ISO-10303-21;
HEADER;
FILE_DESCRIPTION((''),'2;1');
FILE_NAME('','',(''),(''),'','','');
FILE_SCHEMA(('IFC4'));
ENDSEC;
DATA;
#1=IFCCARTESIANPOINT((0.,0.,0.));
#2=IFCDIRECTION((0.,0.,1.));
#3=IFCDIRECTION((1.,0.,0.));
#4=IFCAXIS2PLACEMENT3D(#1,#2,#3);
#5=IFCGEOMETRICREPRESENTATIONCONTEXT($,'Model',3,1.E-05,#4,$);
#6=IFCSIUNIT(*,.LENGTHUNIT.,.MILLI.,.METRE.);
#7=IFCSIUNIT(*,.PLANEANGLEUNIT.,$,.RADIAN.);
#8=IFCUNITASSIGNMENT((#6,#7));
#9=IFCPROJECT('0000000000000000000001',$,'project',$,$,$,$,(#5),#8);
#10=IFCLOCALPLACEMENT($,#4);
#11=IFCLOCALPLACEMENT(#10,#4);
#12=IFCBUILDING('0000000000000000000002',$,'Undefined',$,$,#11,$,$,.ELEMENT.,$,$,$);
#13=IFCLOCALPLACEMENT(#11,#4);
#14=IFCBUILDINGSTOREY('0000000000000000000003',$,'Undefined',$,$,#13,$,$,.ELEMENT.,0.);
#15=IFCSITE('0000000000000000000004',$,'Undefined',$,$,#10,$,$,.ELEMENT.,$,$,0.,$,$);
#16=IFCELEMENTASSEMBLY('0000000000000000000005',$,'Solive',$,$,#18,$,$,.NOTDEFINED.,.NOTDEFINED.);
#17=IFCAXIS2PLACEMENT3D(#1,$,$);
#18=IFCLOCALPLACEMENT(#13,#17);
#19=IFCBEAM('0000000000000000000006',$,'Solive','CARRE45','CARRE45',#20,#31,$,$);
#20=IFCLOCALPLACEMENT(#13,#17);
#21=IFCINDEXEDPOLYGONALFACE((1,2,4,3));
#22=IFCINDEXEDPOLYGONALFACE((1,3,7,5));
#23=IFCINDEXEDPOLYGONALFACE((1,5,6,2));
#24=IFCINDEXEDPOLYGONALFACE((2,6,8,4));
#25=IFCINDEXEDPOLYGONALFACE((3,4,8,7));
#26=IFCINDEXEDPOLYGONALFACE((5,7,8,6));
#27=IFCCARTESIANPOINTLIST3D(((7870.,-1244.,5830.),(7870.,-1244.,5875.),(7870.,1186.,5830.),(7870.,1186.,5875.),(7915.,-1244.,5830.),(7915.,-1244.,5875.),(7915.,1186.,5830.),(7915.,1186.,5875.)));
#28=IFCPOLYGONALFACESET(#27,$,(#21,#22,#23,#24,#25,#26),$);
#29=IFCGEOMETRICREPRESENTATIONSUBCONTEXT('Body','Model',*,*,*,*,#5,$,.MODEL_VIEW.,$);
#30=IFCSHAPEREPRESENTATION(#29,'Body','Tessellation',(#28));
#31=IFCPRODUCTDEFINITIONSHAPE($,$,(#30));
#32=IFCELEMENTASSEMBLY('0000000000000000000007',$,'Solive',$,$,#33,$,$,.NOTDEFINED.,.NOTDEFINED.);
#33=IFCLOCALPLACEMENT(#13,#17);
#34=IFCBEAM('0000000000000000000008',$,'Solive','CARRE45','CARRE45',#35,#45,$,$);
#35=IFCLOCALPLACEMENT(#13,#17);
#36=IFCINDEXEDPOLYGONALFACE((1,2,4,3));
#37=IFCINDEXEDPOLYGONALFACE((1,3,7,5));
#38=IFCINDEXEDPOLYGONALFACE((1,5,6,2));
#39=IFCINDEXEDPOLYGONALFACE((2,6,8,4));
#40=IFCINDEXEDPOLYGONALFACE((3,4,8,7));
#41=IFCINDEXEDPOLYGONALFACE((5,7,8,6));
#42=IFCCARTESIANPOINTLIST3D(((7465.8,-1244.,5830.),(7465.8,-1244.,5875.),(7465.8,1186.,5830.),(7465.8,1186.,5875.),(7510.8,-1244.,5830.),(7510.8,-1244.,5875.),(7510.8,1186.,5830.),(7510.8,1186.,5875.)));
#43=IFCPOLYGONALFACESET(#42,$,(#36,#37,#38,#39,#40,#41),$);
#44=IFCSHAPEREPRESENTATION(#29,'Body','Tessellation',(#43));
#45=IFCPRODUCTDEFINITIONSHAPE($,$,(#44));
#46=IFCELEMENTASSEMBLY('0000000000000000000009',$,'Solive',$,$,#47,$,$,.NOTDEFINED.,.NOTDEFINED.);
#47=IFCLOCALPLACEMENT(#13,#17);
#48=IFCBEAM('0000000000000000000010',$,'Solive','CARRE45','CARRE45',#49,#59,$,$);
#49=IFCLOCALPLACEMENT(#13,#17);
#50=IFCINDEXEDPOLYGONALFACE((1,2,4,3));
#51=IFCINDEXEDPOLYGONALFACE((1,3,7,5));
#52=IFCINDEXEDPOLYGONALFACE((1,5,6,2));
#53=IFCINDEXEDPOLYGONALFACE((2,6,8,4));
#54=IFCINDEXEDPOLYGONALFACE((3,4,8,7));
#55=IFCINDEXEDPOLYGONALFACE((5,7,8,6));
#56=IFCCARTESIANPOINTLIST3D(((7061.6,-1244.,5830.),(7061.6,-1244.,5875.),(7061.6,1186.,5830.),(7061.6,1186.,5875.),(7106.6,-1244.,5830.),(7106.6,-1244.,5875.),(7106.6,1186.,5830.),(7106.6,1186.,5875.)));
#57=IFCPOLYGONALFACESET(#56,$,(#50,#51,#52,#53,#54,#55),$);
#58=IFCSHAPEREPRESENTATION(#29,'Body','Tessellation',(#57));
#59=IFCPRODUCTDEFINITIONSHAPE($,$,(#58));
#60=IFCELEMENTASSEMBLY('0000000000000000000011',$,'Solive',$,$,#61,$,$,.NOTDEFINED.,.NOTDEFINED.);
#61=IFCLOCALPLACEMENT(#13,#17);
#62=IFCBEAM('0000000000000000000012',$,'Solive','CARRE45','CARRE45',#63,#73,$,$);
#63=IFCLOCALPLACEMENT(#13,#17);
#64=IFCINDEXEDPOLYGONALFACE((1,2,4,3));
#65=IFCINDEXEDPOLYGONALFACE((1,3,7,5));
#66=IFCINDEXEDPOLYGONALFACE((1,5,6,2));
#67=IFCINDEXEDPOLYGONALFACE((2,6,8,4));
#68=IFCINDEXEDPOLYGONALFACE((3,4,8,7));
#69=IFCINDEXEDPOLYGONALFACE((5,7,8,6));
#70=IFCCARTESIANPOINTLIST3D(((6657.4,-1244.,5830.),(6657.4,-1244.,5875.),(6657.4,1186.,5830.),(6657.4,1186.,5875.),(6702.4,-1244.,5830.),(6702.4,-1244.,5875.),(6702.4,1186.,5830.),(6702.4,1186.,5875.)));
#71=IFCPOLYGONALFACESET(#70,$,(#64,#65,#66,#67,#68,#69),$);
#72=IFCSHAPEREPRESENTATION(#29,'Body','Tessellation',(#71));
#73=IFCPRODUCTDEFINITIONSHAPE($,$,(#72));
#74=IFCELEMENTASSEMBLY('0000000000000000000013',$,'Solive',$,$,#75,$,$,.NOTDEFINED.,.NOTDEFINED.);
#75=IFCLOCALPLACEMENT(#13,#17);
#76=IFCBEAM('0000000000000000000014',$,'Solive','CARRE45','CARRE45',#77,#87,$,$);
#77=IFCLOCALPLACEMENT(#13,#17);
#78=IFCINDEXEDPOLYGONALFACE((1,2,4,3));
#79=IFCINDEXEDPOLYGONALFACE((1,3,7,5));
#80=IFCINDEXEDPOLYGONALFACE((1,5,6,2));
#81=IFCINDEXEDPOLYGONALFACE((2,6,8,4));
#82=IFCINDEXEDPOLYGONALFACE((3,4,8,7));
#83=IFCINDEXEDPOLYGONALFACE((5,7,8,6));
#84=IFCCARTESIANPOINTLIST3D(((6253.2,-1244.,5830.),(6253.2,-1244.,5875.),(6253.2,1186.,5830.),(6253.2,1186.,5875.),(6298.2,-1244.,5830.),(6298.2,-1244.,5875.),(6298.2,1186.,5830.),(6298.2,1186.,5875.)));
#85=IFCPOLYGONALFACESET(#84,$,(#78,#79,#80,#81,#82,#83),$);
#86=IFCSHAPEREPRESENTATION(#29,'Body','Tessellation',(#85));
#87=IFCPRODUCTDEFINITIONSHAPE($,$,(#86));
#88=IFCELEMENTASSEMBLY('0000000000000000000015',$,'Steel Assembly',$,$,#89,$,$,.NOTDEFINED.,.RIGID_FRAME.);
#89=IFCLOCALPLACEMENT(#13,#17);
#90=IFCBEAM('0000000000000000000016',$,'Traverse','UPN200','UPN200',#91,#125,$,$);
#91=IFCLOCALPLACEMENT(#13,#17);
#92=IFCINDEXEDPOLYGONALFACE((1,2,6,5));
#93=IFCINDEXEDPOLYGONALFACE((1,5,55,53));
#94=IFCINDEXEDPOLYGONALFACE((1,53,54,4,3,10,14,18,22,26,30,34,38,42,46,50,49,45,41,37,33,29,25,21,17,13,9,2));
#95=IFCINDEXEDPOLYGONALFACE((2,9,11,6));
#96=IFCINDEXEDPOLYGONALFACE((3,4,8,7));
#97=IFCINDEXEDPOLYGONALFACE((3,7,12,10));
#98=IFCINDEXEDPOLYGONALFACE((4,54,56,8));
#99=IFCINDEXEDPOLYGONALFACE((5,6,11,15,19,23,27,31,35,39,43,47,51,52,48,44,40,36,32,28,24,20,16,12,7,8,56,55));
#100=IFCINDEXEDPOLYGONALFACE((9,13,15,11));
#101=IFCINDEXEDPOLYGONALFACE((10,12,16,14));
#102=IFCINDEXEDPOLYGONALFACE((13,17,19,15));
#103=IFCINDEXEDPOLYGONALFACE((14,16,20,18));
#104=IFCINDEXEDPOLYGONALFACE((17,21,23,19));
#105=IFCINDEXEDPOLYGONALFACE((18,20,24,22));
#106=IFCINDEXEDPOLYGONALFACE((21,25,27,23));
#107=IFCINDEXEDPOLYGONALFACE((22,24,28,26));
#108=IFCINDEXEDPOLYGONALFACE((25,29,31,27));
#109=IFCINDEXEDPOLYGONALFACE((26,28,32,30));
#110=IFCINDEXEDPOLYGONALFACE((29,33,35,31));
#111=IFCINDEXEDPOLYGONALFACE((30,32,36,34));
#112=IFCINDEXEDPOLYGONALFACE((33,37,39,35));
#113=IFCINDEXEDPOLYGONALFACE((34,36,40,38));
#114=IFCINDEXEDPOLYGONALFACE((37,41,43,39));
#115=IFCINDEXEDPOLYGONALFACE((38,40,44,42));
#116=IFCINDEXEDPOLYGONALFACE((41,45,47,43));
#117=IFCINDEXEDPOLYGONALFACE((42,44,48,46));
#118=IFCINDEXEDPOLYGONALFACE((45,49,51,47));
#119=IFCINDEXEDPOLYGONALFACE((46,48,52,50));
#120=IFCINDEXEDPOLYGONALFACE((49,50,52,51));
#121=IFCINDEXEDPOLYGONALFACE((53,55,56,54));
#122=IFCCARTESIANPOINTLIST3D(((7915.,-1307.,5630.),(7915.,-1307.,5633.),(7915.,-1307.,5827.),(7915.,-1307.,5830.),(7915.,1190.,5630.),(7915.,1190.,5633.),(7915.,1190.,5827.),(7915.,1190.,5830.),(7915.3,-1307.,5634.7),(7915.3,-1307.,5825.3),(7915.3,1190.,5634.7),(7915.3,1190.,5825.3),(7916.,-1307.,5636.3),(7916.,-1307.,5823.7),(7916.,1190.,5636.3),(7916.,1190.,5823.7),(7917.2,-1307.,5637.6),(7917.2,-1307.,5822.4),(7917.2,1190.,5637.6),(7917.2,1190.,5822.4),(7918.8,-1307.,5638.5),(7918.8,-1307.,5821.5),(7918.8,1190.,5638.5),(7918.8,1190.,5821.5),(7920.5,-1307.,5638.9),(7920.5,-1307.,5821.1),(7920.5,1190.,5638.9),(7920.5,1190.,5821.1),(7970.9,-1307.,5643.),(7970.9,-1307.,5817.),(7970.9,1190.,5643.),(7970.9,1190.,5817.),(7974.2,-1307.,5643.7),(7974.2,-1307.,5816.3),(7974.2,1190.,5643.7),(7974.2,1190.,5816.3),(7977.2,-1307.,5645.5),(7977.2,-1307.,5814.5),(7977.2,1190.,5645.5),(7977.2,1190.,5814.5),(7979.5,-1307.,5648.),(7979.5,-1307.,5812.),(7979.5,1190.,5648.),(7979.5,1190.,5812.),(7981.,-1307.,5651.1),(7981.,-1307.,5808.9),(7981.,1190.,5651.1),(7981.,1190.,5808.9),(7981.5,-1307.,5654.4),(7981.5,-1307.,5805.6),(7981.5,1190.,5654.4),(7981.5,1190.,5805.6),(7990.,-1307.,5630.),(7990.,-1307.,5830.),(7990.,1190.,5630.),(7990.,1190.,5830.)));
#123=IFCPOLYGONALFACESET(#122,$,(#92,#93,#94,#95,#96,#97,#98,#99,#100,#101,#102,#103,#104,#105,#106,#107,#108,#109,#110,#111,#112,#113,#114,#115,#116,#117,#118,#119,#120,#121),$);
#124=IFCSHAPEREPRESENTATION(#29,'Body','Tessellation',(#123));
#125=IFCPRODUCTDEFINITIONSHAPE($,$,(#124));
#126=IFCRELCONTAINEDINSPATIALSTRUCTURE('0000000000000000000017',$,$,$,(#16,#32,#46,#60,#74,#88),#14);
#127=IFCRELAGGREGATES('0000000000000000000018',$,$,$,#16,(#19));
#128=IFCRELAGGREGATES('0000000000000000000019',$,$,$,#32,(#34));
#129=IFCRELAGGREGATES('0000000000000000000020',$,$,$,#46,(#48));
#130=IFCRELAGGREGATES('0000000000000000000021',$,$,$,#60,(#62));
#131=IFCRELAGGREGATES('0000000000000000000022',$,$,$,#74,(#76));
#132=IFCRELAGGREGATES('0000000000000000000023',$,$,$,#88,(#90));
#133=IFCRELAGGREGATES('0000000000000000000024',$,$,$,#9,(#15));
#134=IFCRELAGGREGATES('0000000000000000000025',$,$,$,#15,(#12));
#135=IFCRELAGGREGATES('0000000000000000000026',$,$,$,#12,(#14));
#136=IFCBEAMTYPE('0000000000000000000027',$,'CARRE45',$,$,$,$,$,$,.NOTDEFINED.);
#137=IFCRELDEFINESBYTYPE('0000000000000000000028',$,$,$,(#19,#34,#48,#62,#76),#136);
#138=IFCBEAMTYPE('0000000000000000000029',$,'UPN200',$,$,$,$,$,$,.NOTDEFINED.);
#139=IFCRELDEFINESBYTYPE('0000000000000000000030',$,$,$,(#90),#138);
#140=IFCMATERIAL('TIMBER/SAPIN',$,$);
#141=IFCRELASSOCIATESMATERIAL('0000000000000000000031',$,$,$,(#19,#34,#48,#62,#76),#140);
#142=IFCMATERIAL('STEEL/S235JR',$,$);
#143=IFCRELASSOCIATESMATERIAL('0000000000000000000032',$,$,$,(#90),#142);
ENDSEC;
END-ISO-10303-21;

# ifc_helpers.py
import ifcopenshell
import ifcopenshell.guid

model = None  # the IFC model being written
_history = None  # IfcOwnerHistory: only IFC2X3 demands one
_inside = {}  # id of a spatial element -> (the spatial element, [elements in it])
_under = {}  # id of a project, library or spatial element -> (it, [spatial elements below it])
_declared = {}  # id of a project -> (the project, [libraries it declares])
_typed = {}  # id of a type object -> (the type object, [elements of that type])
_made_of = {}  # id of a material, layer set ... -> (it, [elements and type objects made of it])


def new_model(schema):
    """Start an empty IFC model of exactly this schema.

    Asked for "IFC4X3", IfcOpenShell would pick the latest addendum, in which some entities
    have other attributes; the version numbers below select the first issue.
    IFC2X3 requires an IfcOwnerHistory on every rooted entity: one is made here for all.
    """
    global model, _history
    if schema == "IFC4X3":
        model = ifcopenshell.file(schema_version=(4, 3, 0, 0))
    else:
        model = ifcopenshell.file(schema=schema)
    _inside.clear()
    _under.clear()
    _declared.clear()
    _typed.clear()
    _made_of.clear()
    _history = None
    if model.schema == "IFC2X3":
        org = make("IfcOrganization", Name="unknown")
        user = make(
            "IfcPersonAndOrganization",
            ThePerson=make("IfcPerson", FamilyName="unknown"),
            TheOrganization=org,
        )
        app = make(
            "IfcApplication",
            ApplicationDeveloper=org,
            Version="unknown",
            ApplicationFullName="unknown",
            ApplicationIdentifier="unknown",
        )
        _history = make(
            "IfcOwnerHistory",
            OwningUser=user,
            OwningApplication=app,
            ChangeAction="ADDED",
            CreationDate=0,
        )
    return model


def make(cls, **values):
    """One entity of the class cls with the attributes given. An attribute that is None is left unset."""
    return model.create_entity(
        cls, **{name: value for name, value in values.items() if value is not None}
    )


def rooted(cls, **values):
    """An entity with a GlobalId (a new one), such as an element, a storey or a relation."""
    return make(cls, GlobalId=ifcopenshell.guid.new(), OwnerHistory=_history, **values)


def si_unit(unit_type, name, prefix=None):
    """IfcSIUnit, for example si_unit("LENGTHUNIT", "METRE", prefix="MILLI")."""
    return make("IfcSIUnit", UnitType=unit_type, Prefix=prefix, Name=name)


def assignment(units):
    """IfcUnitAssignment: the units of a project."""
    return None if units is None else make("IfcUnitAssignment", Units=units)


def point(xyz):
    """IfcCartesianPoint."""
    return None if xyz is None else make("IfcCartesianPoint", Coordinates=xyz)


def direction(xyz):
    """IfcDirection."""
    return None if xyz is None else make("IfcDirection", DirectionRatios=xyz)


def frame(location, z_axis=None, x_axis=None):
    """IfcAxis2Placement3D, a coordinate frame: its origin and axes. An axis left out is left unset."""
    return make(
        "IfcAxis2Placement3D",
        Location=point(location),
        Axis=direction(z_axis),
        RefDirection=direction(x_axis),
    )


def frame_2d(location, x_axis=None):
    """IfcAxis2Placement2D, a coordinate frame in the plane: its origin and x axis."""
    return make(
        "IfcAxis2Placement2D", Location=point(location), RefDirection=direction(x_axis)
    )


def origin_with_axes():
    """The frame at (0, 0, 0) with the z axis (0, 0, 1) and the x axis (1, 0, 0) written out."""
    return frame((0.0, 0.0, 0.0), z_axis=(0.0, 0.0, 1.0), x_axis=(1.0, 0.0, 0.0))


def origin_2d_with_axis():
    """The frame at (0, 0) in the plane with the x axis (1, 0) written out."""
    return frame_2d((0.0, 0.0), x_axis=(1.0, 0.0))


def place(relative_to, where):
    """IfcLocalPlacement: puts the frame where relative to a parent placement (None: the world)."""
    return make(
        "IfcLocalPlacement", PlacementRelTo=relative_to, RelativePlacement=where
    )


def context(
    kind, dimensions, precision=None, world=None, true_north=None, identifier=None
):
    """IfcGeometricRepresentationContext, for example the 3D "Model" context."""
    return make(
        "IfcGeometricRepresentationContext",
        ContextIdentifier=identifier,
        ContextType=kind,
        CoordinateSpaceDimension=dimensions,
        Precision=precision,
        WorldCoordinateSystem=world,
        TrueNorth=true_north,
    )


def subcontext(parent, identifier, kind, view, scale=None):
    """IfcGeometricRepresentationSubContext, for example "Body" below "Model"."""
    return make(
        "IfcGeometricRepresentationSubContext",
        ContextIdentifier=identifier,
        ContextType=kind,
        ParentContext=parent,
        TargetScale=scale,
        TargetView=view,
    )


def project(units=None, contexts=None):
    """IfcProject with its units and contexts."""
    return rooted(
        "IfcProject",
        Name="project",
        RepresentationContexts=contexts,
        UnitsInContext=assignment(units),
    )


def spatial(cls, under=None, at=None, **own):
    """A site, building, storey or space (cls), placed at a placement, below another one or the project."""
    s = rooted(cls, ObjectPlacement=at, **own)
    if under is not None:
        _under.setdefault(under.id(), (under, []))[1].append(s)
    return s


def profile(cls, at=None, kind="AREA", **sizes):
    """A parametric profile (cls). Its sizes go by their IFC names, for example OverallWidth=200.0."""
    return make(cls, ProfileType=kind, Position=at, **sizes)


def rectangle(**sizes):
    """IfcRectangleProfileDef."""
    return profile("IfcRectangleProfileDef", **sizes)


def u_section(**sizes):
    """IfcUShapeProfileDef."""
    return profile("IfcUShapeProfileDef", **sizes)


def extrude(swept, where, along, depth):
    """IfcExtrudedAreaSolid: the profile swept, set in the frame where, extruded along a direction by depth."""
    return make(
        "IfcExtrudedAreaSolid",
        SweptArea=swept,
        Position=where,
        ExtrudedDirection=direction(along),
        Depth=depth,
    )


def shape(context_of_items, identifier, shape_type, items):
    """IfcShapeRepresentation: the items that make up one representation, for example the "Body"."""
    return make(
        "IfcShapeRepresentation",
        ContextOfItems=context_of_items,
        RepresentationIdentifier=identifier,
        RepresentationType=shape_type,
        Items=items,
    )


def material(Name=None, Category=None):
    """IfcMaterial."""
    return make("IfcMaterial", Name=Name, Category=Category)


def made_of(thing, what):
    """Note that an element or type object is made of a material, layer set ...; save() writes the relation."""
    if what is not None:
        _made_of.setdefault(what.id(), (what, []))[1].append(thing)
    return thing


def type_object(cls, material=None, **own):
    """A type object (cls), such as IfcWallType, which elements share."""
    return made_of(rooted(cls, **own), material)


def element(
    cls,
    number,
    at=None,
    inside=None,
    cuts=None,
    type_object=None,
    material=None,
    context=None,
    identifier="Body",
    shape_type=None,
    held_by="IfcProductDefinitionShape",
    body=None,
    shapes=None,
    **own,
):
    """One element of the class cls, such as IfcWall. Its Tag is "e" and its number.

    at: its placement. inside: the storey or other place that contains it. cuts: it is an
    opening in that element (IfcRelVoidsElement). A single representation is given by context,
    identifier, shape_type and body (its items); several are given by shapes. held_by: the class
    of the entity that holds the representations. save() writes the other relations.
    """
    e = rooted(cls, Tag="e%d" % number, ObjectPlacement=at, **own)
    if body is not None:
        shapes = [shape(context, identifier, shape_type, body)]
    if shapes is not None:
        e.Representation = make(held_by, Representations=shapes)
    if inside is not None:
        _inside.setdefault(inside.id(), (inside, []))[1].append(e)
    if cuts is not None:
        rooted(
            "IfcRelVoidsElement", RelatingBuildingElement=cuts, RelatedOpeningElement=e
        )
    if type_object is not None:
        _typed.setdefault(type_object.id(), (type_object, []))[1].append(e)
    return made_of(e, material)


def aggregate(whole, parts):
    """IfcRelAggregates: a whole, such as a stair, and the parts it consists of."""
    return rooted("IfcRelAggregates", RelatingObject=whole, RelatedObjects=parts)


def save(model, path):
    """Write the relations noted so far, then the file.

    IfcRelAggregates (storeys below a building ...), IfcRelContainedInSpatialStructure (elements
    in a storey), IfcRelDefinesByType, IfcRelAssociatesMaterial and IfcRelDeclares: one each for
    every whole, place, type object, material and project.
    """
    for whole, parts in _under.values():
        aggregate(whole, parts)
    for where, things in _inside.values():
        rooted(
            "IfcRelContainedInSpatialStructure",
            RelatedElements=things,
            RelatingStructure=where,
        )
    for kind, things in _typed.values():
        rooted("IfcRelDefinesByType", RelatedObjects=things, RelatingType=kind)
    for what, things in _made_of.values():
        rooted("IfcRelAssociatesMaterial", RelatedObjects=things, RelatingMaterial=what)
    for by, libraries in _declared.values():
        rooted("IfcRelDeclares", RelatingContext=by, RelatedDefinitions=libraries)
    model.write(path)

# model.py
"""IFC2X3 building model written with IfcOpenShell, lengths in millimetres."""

from ifc_helpers import new_model, si_unit, frame, origin_with_axes, origin_2d_with_axis, place, context, subcontext, project, spatial, rectangle, u_section, extrude, material, type_object, element, aggregate, save


model = new_model("IFC2X3")

# Units and contexts
model_context = context("Model", 3, precision=1e-05, world=origin_with_axes())
body_context = subcontext(model_context, "Body", "Model", "MODEL_VIEW")
ifc_project = project(units=[si_unit("LENGTHUNIT", "METRE", prefix="MILLI"), si_unit("PLANEANGLEUNIT", "RADIAN")], contexts=[model_context])

# Site, building, storey
site_placement = place(None, origin_with_axes())
site = spatial("IfcSite", under=ifc_project, at=site_placement, Name="Undefined", CompositionType="ELEMENT", RefElevation=0.0)
building_placement = place(site_placement, origin_with_axes())
building = spatial("IfcBuilding", under=site, at=building_placement, Name="Undefined", CompositionType="ELEMENT")
storey_placement = place(building_placement, origin_with_axes())
storey = spatial("IfcBuildingStorey", under=building, at=storey_placement, Name="Undefined", CompositionType="ELEMENT", Elevation=0.0)

# Element assemblies, beams
ifc_material_1 = material(Name="STEEL/S235JR")
assembly_1_placement = place(storey_placement, origin_with_axes())
assembly_1 = element("IfcElementAssembly", 1, at=assembly_1_placement, inside=storey, Name="Solive", AssemblyPlace="NOTDEFINED", PredefinedType="NOTDEFINED")
ifc_material_2 = material(Name="TIMBER/SAPIN")
beam_type_1 = type_object("IfcBeamType", Name="CARRE45", PredefinedType="NOTDEFINED")
beam_1_placement = place(assembly_1_placement, frame((7892.5, 1186.0, 5852.5), z_axis=(0.0, 0.0, -1.0), x_axis=(0.0, -1.0, 0.0)))
beam_1 = element("IfcBeam", 2, at=beam_1_placement, type_object=beam_type_1, material=ifc_material_2, Name="Solive", Description="CARRE45", ObjectType="CARRE45", context=body_context, shape_type="SweptSolid", body=[
    extrude(rectangle(XDim=45.0, YDim=45.0, at=origin_2d_with_axis()), frame((2430.0, 0.0, 0.0), z_axis=(-1.0, 0.0, 0.0), x_axis=(0.0, -1.0, 0.0)), (0.0, 0.0, 1.0), 2430.0),
])
aggregate(assembly_1, [beam_1])
assembly_2_placement = place(storey_placement, origin_with_axes())
assembly_2 = element("IfcElementAssembly", 3, at=assembly_2_placement, inside=storey, Name="Solive", AssemblyPlace="NOTDEFINED", PredefinedType="NOTDEFINED")
beam_2_placement = place(assembly_2_placement, frame((7488.3, 1186.0, 5852.5), z_axis=(0.0, 0.0, -1.0), x_axis=(0.0, -1.0, 0.0)))
beam_2 = element("IfcBeam", 4, at=beam_2_placement, type_object=beam_type_1, material=ifc_material_2, Name="Solive", Description="CARRE45", ObjectType="CARRE45", context=body_context, shape_type="SweptSolid", body=[
    extrude(rectangle(XDim=45.0, YDim=45.0, at=origin_2d_with_axis()), frame((2430.0, 0.0, 0.0), z_axis=(-1.0, 0.0, 0.0), x_axis=(0.0, -1.0, 0.0)), (0.0, 0.0, 1.0), 2430.0),
])
aggregate(assembly_2, [beam_2])
assembly_3_placement = place(storey_placement, origin_with_axes())
assembly_3 = element("IfcElementAssembly", 5, at=assembly_3_placement, inside=storey, Name="Solive", AssemblyPlace="NOTDEFINED", PredefinedType="NOTDEFINED")
beam_3_placement = place(assembly_3_placement, frame((7084.1, 1186.0, 5852.5), z_axis=(0.0, 0.0, -1.0), x_axis=(0.0, -1.0, 0.0)))
beam_3 = element("IfcBeam", 6, at=beam_3_placement, type_object=beam_type_1, material=ifc_material_2, Name="Solive", Description="CARRE45", ObjectType="CARRE45", context=body_context, shape_type="SweptSolid", body=[
    extrude(rectangle(XDim=45.0, YDim=45.0, at=origin_2d_with_axis()), frame((2430.0, 0.0, 0.0), z_axis=(-1.0, 0.0, 0.0), x_axis=(0.0, -1.0, 0.0)), (0.0, 0.0, 1.0), 2430.0),
])
aggregate(assembly_3, [beam_3])
assembly_4_placement = place(storey_placement, origin_with_axes())
assembly_4 = element("IfcElementAssembly", 7, at=assembly_4_placement, inside=storey, Name="Solive", AssemblyPlace="NOTDEFINED", PredefinedType="NOTDEFINED")
beam_4_placement = place(assembly_4_placement, frame((6679.9, 1186.0, 5852.5), z_axis=(0.0, 0.0, -1.0), x_axis=(0.0, -1.0, 0.0)))
beam_4 = element("IfcBeam", 8, at=beam_4_placement, type_object=beam_type_1, material=ifc_material_2, Name="Solive", Description="CARRE45", ObjectType="CARRE45", context=body_context, shape_type="SweptSolid", body=[
    extrude(rectangle(XDim=45.0, YDim=45.0, at=origin_2d_with_axis()), frame((2430.0, 0.0, 0.0), z_axis=(-1.0, 0.0, 0.0), x_axis=(0.0, -1.0, 0.0)), (0.0, 0.0, 1.0), 2430.0),
])
aggregate(assembly_4, [beam_4])
assembly_5_placement = place(storey_placement, origin_with_axes())
assembly_5 = element("IfcElementAssembly", 9, at=assembly_5_placement, inside=storey, Name="Solive", AssemblyPlace="NOTDEFINED", PredefinedType="NOTDEFINED")
beam_5_placement = place(assembly_5_placement, frame((6275.7, 1186.0, 5852.5), z_axis=(0.0, 0.0, -1.0), x_axis=(0.0, -1.0, 0.0)))
beam_5 = element("IfcBeam", 10, at=beam_5_placement, type_object=beam_type_1, material=ifc_material_2, Name="Solive", Description="CARRE45", ObjectType="CARRE45", context=body_context, shape_type="SweptSolid", body=[
    extrude(rectangle(XDim=45.0, YDim=45.0, at=origin_2d_with_axis()), frame((2430.0, 0.0, 0.0), z_axis=(-1.0, 0.0, 0.0), x_axis=(0.0, -1.0, 0.0)), (0.0, 0.0, 1.0), 2430.0),
])
aggregate(assembly_5, [beam_5])
assembly_6_placement = place(storey_placement, origin_with_axes())
assembly_6 = element("IfcElementAssembly", 11, at=assembly_6_placement, inside=storey, Name="Steel Assembly", AssemblyPlace="NOTDEFINED", PredefinedType="RIGID_FRAME")
beam_type_2 = type_object("IfcBeamType", Name="UPN200", PredefinedType="NOTDEFINED")
beam_6_placement = place(assembly_6_placement, frame((7952.5, -1307.0, 5730.0), z_axis=(0.0, 0.0, -1.0), x_axis=(0.0, 1.0, 0.0)))
beam_6 = element("IfcBeam", 12, at=beam_6_placement, type_object=beam_type_2, material=ifc_material_1, Name="Traverse", Description="UPN200", ObjectType="UPN200", context=body_context, shape_type="SweptSolid", body=[
    extrude(u_section(Depth=200.0, FlangeWidth=75.0, WebThickness=8.5, FlangeThickness=11.5, FilletRadius=11.5, EdgeRadius=6.0, FlangeSlope=0.07983, at=origin_2d_with_axis()), frame((2497.0, 0.0, 0.0), z_axis=(-1.0, 0.0, 0.0), x_axis=(0.0, -1.0, 0.0)), (0.0, 0.0, 1.0), 2497.0),
])

aggregate(assembly_6, [beam_6])

save(model, "model.ifc")
